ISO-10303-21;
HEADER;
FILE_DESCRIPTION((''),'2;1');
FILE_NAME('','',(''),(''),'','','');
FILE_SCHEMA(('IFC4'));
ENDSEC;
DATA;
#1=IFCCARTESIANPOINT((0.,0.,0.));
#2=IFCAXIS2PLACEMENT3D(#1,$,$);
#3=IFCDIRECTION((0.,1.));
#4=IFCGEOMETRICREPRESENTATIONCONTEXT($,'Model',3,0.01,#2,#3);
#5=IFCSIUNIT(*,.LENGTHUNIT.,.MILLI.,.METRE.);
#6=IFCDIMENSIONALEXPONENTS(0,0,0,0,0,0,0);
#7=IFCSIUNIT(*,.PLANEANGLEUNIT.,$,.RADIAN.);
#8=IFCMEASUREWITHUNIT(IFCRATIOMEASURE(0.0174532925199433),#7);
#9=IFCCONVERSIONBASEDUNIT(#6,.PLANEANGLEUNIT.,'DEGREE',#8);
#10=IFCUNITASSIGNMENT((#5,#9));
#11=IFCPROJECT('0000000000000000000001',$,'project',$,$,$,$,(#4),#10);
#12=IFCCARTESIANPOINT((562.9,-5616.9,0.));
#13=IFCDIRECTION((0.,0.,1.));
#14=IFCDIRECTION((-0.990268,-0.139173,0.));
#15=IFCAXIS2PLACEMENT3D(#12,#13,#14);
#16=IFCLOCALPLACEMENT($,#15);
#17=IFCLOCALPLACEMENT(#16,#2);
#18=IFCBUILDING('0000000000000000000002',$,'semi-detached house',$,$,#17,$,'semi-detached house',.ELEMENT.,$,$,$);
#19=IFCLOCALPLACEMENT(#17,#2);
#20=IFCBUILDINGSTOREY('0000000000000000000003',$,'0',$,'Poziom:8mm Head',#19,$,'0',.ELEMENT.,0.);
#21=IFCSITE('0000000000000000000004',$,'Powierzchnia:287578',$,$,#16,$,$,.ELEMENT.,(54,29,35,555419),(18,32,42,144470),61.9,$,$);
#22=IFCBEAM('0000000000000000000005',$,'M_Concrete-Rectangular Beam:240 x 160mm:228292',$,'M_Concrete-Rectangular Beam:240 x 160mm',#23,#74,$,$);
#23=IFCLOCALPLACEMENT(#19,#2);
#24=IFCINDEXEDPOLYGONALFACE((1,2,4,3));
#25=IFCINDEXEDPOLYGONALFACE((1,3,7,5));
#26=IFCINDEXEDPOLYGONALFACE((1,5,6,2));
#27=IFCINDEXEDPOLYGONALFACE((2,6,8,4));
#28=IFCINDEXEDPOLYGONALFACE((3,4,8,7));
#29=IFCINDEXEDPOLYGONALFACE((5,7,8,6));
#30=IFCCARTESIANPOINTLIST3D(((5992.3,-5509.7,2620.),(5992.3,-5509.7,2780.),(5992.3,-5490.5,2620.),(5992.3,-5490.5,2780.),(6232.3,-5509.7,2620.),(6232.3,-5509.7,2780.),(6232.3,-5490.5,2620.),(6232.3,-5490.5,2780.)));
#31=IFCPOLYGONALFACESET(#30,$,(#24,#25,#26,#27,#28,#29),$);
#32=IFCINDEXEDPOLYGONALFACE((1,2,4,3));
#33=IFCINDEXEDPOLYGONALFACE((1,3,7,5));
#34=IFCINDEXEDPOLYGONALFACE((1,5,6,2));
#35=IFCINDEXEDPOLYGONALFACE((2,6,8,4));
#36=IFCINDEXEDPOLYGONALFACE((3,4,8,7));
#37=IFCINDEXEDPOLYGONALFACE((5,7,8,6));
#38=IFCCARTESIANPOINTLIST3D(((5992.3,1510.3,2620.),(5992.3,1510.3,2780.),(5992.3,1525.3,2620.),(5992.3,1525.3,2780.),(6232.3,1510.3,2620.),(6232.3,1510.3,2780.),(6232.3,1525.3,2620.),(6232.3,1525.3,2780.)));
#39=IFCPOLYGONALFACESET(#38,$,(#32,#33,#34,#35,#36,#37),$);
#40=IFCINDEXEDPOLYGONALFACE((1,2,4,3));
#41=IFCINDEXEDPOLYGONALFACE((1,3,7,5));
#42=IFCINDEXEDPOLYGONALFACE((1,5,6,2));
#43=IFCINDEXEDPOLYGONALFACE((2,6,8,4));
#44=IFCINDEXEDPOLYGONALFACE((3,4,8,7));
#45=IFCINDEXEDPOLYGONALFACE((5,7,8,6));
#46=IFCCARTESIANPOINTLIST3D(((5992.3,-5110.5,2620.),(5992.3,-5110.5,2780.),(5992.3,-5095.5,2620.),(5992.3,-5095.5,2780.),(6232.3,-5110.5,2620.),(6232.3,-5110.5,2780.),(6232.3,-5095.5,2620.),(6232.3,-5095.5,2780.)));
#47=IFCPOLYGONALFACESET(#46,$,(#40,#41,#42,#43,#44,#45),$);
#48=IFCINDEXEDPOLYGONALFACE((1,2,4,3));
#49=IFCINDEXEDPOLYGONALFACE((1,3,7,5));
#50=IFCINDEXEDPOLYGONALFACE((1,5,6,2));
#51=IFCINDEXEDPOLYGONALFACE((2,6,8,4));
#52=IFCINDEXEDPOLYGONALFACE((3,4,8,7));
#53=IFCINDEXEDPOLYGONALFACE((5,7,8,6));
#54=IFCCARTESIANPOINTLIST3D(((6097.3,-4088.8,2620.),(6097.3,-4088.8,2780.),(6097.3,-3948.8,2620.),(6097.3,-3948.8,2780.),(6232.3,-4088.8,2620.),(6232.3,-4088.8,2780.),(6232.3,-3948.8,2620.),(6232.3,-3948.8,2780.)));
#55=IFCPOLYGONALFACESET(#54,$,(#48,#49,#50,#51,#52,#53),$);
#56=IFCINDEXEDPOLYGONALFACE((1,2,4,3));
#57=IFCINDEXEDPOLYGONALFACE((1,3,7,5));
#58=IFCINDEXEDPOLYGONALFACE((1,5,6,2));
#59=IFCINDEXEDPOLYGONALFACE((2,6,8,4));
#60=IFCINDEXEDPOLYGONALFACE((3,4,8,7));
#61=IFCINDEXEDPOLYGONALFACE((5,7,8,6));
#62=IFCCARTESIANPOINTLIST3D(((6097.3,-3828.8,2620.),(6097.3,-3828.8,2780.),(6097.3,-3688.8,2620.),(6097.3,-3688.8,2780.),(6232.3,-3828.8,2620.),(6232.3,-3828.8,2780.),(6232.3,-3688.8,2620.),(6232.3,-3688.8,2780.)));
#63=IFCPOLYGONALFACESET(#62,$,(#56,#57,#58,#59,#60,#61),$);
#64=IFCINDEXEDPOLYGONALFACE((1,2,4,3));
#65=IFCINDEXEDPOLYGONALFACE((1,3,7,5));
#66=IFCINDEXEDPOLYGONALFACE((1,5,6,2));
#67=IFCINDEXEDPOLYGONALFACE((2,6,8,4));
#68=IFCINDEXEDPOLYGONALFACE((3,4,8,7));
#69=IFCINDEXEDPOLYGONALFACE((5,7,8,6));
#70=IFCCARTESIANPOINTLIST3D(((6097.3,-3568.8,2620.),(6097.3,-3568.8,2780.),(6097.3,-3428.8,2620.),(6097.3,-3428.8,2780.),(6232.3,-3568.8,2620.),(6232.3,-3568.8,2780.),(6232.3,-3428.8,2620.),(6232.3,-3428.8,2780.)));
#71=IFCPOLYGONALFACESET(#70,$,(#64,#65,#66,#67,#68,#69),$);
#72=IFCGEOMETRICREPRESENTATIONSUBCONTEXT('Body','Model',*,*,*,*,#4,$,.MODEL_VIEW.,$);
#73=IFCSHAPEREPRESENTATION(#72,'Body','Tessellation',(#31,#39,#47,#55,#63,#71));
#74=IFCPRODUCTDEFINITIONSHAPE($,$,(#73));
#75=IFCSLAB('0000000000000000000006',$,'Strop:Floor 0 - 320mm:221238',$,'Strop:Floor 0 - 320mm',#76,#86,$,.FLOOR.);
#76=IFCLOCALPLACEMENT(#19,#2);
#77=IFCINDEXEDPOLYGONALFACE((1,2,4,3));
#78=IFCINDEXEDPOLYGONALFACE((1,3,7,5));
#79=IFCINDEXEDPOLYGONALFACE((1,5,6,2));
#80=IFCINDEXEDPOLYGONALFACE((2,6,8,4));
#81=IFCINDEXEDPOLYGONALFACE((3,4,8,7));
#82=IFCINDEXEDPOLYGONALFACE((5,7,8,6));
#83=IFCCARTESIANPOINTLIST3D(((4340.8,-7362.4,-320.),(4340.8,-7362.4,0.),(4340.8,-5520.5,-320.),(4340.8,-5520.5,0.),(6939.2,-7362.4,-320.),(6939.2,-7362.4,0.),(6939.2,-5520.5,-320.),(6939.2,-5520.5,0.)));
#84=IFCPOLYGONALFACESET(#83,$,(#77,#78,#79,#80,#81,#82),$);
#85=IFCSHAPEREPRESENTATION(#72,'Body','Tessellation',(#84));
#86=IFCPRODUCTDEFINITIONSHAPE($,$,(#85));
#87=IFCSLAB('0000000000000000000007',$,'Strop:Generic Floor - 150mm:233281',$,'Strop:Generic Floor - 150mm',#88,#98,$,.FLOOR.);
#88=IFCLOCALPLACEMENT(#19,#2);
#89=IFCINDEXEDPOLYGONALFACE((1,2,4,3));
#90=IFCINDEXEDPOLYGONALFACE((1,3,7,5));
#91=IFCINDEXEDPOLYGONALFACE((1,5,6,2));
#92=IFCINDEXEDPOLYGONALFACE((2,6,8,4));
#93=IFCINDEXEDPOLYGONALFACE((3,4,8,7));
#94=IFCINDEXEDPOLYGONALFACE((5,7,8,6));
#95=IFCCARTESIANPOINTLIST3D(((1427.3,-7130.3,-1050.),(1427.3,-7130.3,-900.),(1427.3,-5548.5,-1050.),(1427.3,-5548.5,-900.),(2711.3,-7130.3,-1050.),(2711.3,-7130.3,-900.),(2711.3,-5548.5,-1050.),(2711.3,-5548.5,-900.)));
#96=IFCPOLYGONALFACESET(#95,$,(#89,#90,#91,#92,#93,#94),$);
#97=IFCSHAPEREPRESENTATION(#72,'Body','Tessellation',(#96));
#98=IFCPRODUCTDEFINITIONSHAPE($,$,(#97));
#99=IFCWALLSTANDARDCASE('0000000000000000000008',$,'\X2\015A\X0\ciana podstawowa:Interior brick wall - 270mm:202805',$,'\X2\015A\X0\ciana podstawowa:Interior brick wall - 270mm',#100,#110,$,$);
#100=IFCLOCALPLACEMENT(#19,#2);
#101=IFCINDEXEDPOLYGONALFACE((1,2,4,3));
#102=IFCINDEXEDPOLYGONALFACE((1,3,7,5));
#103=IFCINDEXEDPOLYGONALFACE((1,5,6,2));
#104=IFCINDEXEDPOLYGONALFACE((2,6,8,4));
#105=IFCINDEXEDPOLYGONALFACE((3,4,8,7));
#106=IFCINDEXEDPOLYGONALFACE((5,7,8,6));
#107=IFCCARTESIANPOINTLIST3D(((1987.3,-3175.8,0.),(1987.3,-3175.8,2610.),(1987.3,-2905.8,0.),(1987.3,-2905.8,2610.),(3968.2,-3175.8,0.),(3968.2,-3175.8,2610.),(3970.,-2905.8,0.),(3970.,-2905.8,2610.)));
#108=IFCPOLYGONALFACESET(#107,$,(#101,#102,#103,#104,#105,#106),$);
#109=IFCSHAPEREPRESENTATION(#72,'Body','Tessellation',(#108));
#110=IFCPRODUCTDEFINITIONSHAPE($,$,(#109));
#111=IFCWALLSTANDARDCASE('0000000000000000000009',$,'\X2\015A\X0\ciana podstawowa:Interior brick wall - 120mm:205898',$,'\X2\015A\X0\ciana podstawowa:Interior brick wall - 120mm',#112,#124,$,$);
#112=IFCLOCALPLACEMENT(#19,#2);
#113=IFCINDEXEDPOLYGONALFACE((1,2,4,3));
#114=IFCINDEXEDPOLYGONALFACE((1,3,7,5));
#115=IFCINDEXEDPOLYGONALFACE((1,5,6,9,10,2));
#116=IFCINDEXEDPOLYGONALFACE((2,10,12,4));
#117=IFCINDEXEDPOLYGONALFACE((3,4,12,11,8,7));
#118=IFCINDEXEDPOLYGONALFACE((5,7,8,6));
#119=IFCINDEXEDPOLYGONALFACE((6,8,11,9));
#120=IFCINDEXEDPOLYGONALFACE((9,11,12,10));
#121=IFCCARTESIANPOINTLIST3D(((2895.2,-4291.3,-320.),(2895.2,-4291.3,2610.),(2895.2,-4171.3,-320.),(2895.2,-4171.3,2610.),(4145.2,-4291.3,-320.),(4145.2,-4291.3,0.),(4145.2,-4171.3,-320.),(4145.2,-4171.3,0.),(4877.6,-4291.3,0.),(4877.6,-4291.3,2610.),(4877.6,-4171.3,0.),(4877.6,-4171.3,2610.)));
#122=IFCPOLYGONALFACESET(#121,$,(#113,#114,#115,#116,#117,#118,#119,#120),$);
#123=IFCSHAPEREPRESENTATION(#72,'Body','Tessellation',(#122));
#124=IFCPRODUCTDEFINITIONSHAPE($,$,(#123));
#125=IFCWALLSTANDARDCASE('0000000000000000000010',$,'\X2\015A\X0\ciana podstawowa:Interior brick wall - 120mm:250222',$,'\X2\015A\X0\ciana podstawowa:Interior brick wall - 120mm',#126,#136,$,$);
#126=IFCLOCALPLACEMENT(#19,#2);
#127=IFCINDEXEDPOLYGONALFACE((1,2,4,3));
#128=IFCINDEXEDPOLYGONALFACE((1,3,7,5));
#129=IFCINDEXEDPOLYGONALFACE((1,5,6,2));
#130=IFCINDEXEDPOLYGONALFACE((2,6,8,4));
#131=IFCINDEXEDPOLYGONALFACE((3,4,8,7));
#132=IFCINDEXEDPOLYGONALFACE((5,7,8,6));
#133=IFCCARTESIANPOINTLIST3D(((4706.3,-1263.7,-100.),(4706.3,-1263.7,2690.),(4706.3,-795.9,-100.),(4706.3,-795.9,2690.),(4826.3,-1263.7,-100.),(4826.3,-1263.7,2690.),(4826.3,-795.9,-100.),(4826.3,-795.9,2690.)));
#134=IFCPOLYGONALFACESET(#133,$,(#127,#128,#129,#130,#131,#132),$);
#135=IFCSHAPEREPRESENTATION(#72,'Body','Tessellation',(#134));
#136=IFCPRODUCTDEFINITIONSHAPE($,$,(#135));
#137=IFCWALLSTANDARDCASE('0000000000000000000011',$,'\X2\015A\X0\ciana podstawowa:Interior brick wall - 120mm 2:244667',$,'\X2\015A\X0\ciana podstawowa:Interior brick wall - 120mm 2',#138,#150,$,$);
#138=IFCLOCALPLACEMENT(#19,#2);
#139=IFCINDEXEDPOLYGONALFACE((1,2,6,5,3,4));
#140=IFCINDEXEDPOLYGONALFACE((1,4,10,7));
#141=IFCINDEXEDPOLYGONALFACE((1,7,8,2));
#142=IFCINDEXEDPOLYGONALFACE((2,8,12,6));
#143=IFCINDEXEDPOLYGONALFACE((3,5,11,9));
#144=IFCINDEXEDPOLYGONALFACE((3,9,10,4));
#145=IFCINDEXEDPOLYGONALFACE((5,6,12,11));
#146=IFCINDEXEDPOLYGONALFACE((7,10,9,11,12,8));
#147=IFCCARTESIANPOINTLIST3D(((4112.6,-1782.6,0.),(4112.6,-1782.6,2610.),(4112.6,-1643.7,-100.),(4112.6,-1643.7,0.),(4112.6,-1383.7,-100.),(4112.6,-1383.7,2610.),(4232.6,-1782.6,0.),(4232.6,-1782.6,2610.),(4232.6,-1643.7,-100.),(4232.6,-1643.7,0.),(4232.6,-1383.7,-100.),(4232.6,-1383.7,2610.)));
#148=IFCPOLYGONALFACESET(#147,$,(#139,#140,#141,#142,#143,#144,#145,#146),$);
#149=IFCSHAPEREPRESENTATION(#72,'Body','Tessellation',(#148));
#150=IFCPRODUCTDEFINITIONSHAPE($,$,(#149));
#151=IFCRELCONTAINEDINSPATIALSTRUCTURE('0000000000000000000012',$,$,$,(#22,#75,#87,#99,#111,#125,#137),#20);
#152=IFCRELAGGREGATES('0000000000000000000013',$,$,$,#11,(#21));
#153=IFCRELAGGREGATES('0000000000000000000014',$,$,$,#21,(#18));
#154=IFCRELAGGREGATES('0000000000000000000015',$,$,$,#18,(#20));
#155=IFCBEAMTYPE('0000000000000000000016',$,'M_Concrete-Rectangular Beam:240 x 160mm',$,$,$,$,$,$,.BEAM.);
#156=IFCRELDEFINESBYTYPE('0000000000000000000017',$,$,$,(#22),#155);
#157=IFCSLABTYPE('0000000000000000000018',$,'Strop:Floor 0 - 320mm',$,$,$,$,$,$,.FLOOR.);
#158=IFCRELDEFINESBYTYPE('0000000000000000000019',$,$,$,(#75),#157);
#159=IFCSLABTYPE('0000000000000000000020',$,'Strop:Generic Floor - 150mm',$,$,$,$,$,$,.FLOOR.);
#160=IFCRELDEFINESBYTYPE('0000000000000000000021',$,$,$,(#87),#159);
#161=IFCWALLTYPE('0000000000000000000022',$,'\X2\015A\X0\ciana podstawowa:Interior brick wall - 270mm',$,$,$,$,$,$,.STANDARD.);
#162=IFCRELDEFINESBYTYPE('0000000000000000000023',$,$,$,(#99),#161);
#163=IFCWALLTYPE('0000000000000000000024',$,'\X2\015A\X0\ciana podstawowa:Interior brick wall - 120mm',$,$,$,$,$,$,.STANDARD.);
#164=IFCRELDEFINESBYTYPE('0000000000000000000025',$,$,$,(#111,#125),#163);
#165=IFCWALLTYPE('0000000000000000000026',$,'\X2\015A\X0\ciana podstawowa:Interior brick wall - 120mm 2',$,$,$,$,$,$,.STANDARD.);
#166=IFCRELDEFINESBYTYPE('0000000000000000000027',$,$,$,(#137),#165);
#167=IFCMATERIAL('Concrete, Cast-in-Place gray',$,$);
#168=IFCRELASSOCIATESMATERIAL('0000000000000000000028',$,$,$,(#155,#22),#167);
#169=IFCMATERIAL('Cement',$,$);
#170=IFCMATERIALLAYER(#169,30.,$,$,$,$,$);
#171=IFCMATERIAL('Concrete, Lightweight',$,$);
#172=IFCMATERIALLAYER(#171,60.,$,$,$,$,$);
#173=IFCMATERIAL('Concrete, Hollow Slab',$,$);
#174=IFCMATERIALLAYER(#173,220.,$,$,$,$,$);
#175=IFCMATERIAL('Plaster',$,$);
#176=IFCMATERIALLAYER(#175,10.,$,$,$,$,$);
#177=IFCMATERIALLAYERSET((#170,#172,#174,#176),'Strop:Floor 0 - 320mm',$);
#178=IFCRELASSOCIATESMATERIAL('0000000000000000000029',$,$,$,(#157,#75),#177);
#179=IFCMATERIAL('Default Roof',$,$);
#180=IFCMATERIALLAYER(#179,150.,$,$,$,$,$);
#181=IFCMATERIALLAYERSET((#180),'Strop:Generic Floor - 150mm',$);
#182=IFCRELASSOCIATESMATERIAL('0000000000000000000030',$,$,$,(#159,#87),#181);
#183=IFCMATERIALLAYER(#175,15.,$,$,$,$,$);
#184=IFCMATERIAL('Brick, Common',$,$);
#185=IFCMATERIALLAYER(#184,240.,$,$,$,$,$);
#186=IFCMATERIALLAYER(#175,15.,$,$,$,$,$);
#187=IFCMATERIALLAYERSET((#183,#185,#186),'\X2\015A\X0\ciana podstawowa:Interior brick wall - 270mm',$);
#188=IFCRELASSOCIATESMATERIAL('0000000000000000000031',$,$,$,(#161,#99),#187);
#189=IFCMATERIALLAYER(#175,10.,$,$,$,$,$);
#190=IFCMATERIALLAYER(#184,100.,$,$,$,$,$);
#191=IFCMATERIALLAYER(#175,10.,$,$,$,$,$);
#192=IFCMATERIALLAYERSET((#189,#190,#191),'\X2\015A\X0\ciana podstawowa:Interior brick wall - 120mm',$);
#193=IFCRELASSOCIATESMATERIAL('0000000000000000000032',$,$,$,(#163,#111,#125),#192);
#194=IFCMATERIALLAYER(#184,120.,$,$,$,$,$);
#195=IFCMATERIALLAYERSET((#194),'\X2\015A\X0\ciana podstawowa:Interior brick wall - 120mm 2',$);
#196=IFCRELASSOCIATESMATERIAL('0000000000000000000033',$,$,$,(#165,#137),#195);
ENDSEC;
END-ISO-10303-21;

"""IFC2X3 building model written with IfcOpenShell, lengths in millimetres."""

from ifc_helpers import new_model, entity, si_unit, converted_unit, direction, frame, frame_2d, origin, origin_2d_with_axis, place, context, subcontext, project, spatial, polyline, rectangle, outline, extrude, clip, bounded_halfspace, source, transform, mapped, material, layer, layer_set, layer_usage, type_object, type_shapes, element, save


model = new_model("IFC2X3")

# Units and contexts
model_context = context("Model", 3, precision=0.01, world=origin(), true_north=direction((0.0, 1.0)))
body_context = subcontext(model_context, "Body", "Model", "MODEL_VIEW")
ifc_project = project(units=[si_unit("LENGTHUNIT", "METRE", prefix="MILLI"), converted_unit("PLANEANGLEUNIT", "DEGREE", entity("IfcRatioMeasure", 0.0174532925199433), si_unit("PLANEANGLEUNIT", "RADIAN"), dimensions=[0, 0, 0, 0, 0, 0, 0])], contexts=[model_context])

# Site, building, storey
site_placement = place(None, frame((562.9, -5616.9, 0.0), z_axis=(0.0, 0.0, 1.0), x_axis=(-0.990268, -0.139173, 0.0)))
site = spatial("IfcSite", under=ifc_project, at=site_placement, Name="Powierzchnia:287578", CompositionType="ELEMENT", RefLatitude=(54, 29, 35, 555419), RefLongitude=(18, 32, 42, 144470), RefElevation=61.9)
building_placement = place(site_placement, origin())
building = spatial("IfcBuilding", under=site, at=building_placement, Name="semi-detached house", LongName="semi-detached house", CompositionType="ELEMENT")
storey_placement = place(building_placement, origin())
storey = spatial("IfcBuildingStorey", under=building, at=storey_placement, Name="0", ObjectType="Poziom:8mm Head", LongName="0", CompositionType="ELEMENT", Elevation=0.0)

# Beam
ifc_material_1 = material(Name="Concrete, Cast-in-Place gray")
beam_type_1 = type_object("IfcBeamType", Name="M_Concrete-Rectangular Beam:240 x 160mm", PredefinedType="BEAM", material=ifc_material_1)
shared_shape_1 = source(origin(), body_context, "Body", "SweptSolid", [
    extrude(rectangle(XDim=160.0, YDim=240.0, at=frame_2d((0.0, 0.0), x_axis=(0.0, 1.0))), frame((6112.3, -5490.5, 2700.0), z_axis=(0.0, -1.0, 0.0), x_axis=(-1.0, 0.0, 0.0)), (0.0, 0.0, 1.0), 19.2),
    extrude(rectangle(XDim=160.0, YDim=240.0, at=frame_2d((0.0, 0.0), x_axis=(0.0, 1.0))), frame((6112.3, 1525.3, 2700.0), z_axis=(0.0, -1.0, 0.0), x_axis=(-1.0, 0.0, 0.0)), (0.0, 0.0, 1.0), 15.0),
    extrude(rectangle(XDim=160.0, YDim=240.0, at=frame_2d((0.0, 0.0), x_axis=(0.0, 1.0))), frame((6112.3, -5095.5, 2700.0), z_axis=(0.0, -1.0, 0.0), x_axis=(-1.0, 0.0, 0.0)), (0.0, 0.0, 1.0), 15.0),
    extrude(rectangle(XDim=160.0, YDim=135.0, at=frame_2d((0.0, 0.0), x_axis=(1.0, 0.0))), frame((6164.8, -3948.8, 2700.0), z_axis=(0.0, -1.0, 0.0), x_axis=(0.0, 0.0, -1.0)), (0.0, 0.0, 1.0), 140.0),
    extrude(rectangle(XDim=160.0, YDim=135.0, at=frame_2d((0.0, 0.0), x_axis=(1.0, 0.0))), frame((6164.8, -3688.8, 2700.0), z_axis=(0.0, -1.0, 0.0), x_axis=(0.0, 0.0, -1.0)), (0.0, 0.0, 1.0), 140.0),
    extrude(rectangle(XDim=160.0, YDim=135.0, at=frame_2d((0.0, 0.0), x_axis=(1.0, 0.0))), frame((6164.8, -3428.8, 2700.0), z_axis=(0.0, -1.0, 0.0), x_axis=(0.0, 0.0, -1.0)), (0.0, 0.0, 1.0), 140.0),
])
type_shapes(beam_type_1, [shared_shape_1])
beam_1_placement = place(storey_placement, origin())
element("IfcBeam", 1, at=beam_1_placement, inside=storey, type_object=beam_type_1, material=ifc_material_1, Name="M_Concrete-Rectangular Beam:240 x 160mm:228292", ObjectType="M_Concrete-Rectangular Beam:240 x 160mm", context=body_context, shape_type="MappedRepresentation", body=[
    mapped(shared_shape_1, transform((0.0, 0.0, 0.0), scale=1.0)),
])

# Slabs
ifc_material_2 = material(Name="Cement")
ifc_layer_1 = layer(ifc_material_2, 30.0)
ifc_material_3 = material(Name="Concrete, Lightweight")
ifc_layer_2 = layer(ifc_material_3, 60.0)
ifc_material_4 = material(Name="Concrete, Hollow Slab")
ifc_layer_3 = layer(ifc_material_4, 220.0)
ifc_material_5 = material(Name="Plaster")
ifc_layer_4 = layer(ifc_material_5, 10.0)
ifc_layer_set_1 = layer_set([ifc_layer_1, ifc_layer_2, ifc_layer_3, ifc_layer_4], Name="Strop:Floor 0 - 320mm")
ifc_layer_usage_1 = layer_usage(ifc_layer_set_1, "AXIS3", "POSITIVE", 0.0)
slab_type_1 = type_object("IfcSlabType", Name="Strop:Floor 0 - 320mm", PredefinedType="FLOOR", material=ifc_layer_set_1)
slab_1_placement = place(storey_placement, origin())
element("IfcSlab", 2, at=slab_1_placement, inside=storey, type_object=slab_type_1, material=ifc_layer_usage_1, Name="Strop:Floor 0 - 320mm:221238", ObjectType="Strop:Floor 0 - 320mm", PredefinedType="FLOOR", context=body_context, shape_type="SweptSolid", body=[
    extrude(rectangle(XDim=1841.8, YDim=2598.3, at=frame_2d((0.0, 0.0), x_axis=(1.0, 0.0))), frame((5640.0, -6441.4, 0.0), z_axis=(0.0, 0.0, -1.0), x_axis=(0.0, 1.0, 0.0)), (0.0, 0.0, 1.0), 320.0),
])
ifc_material_6 = material(Name="Default Roof")
ifc_layer_5 = layer(ifc_material_6, 150.0)
ifc_layer_set_2 = layer_set([ifc_layer_5], Name="Strop:Generic Floor - 150mm")
ifc_layer_usage_2 = layer_usage(ifc_layer_set_2, "AXIS3", "POSITIVE", 0.0)
slab_type_2 = type_object("IfcSlabType", Name="Strop:Generic Floor - 150mm", PredefinedType="FLOOR", material=ifc_layer_set_2)
slab_2_placement = place(storey_placement, origin())
element("IfcSlab", 3, at=slab_2_placement, inside=storey, type_object=slab_type_2, material=ifc_layer_usage_2, Name="Strop:Generic Floor - 150mm:233281", ObjectType="Strop:Generic Floor - 150mm", PredefinedType="FLOOR", context=body_context, shape_type="SweptSolid", body=[
    extrude(rectangle(XDim=1581.8, YDim=1284.0, at=origin_2d_with_axis()), frame((2069.3, -6339.4, -900.0), z_axis=(0.0, 0.0, -1.0), x_axis=(0.0, 1.0, 0.0)), (0.0, 0.0, 1.0), 150.0),
])

# Shared definitions
ifc_material_7 = material(Name="Brick, Common")

# Wall
ifc_layer_6 = layer(ifc_material_5, 15.0)
ifc_layer_7 = layer(ifc_material_7, 240.0)
ifc_layer_8 = layer(ifc_material_5, 15.0)
ifc_layer_set_3 = layer_set([ifc_layer_6, ifc_layer_7, ifc_layer_8], Name="Ściana podstawowa:Interior brick wall - 270mm")
ifc_layer_usage_3 = layer_usage(ifc_layer_set_3, "AXIS2", "NEGATIVE", 135.0)
wall_type_1 = type_object("IfcWallType", Name="Ściana podstawowa:Interior brick wall - 270mm", PredefinedType="STANDARD", material=ifc_layer_set_3)
wall_1_placement = place(storey_placement, frame((1987.3, -3040.8, 0.0)))
element("IfcWallStandardCase", 4, at=wall_1_placement, inside=storey, type_object=wall_type_1, material=ifc_layer_usage_3, Name="Ściana podstawowa:Interior brick wall - 270mm:202805", ObjectType="Ściana podstawowa:Interior brick wall - 270mm", context=body_context, shape_type="Clipping", body=[
    clip(extrude(outline(polyline([(0.0, -135.0), (1980.9, -135.0), (1982.7, 135.0), (1782.7, 135.0), (0.0, 135.0), (0.0, -135.0)])), origin(), (0.0, 0.0, 1.0), 2610.0), bounded_halfspace(frame((1980.9, -135.0, 0.0), z_axis=(0.0, 0.0, 1.0), x_axis=(0.0, -1.0, 0.0)), True, frame((1980.9, -135.0, 0.0), z_axis=(0.0, 0.0, 1.0), x_axis=(0.0, -1.0, 0.0)), polyline([(0.0, 0.0), (-270.0, 1.8), (-270.0, -1980.9), (0.0, -1980.9), (0.0, 0.0)]))),
])

# Walls
ifc_layer_9 = layer(ifc_material_5, 10.0)
ifc_layer_10 = layer(ifc_material_7, 100.0)
ifc_layer_11 = layer(ifc_material_5, 10.0)
ifc_layer_set_4 = layer_set([ifc_layer_9, ifc_layer_10, ifc_layer_11], Name="Ściana podstawowa:Interior brick wall - 120mm")
ifc_layer_usage_4 = layer_usage(ifc_layer_set_4, "AXIS2", "NEGATIVE", 60.0)
wall_type_2 = type_object("IfcWallType", Name="Ściana podstawowa:Interior brick wall - 120mm", PredefinedType="STANDARD", material=ifc_layer_set_4)
wall_2_placement = place(storey_placement, frame((2895.2, -4231.3, -320.0)))
element("IfcWallStandardCase", 5, at=wall_2_placement, inside=storey, type_object=wall_type_2, material=ifc_layer_usage_4, Name="Ściana podstawowa:Interior brick wall - 120mm:205898", ObjectType="Ściana podstawowa:Interior brick wall - 120mm", context=body_context, shape_type="Clipping", body=[
    clip(clip(extrude(rectangle(XDim=1982.4, YDim=120.0, at=frame_2d((991.2, 0.0), x_axis=(-1.0, 0.0))), origin(), (0.0, 0.0, 1.0), 2930.0), bounded_halfspace(frame((1250.0, -60.0, 320.0), z_axis=(0.0, 0.0, 1.0), x_axis=(0.0, -1.0, 0.0)), True, frame((1250.0, -60.0, 320.0), z_axis=(0.0, 0.0, 1.0), x_axis=(0.0, -1.0, 0.0)), polyline([(0.0, 0.0), (0.0, 732.4), (-120.0, 732.4), (-120.0, 334.6), (-120.0, 0.0), (0.0, 0.0)]))), bounded_halfspace(frame((1250.0, 60.0, 320.0), z_axis=(-1.0, 0.0, 0.0), x_axis=(0.0, 0.0, 1.0)), True, frame((1250.0, 60.0, 320.0), z_axis=(-1.0, 0.0, 0.0), x_axis=(0.0, 0.0, 1.0)), polyline([(0.0, 0.0), (-320.0, 0.0), (-320.0, -120.0), (0.0, -120.0), (0.0, 0.0)]))),
])
ifc_layer_usage_5 = layer_usage(ifc_layer_set_4, "AXIS2", "POSITIVE", -60.0)
wall_3_placement = place(storey_placement, frame((4766.3, -795.9, -100.0), z_axis=(0.0, 0.0, 1.0), x_axis=(0.0, -1.0, 0.0)))
element("IfcWallStandardCase", 6, at=wall_3_placement, inside=storey, type_object=wall_type_2, material=ifc_layer_usage_5, Name="Ściana podstawowa:Interior brick wall - 120mm:250222", ObjectType="Ściana podstawowa:Interior brick wall - 120mm", context=body_context, shape_type="SweptSolid", body=[
    extrude(rectangle(XDim=467.9, YDim=120.0, at=frame_2d((233.9, 0.0), x_axis=(-1.0, 0.0))), origin(), (0.0, 0.0, 1.0), 2790.0),
])
ifc_layer_12 = layer(ifc_material_7, 120.0)
ifc_layer_set_5 = layer_set([ifc_layer_12], Name="Ściana podstawowa:Interior brick wall - 120mm 2")
wall_type_3 = type_object("IfcWallType", Name="Ściana podstawowa:Interior brick wall - 120mm 2", PredefinedType="STANDARD", material=ifc_layer_set_5)
ifc_layer_usage_6 = layer_usage(ifc_layer_set_5, "AXIS2", "POSITIVE", -60.0)
wall_4_placement = place(storey_placement, frame((4172.6, -1383.7, -100.0), z_axis=(0.0, 0.0, 1.0), x_axis=(0.0, -1.0, 0.0)))
element("IfcWallStandardCase", 7, at=wall_4_placement, inside=storey, type_object=wall_type_3, material=ifc_layer_usage_6, Name="Ściana podstawowa:Interior brick wall - 120mm 2:244667", ObjectType="Ściana podstawowa:Interior brick wall - 120mm 2", context=body_context, shape_type="Clipping", body=[
    clip(clip(clip(extrude(rectangle(XDim=398.9, YDim=120.0, at=frame_2d((199.5, 0.0), x_axis=(-1.0, 0.0))), origin(), (0.0, 0.0, 1.0), 2710.0), bounded_halfspace(frame((0.0, -60.0, 2710.0), z_axis=(0.0, 0.0, -1.0), x_axis=(0.0, 1.0, 0.0)), True, frame((0.0, -60.0, 2710.0)), polyline([(0.0, 0.0), (138.9, 0.0), (140.0, 0.0), (260.0, 0.0), (398.9, 0.0), (398.9, 120.0), (260.0, 120.0), (140.0, 120.0), (138.9, 120.0), (0.0, 120.0), (0.0, 0.0)]))), bounded_halfspace(frame((260.0, -60.0, 100.0)), True, frame((260.0, -60.0, 100.0)), polyline([(0.0, 0.0), (138.9, 0.0), (138.9, 120.0), (0.0, 120.0), (0.0, 0.0)]))), bounded_halfspace(frame((260.0, 60.0, 100.0), z_axis=(-1.0, 0.0, 0.0), x_axis=(0.0, 0.0, 1.0)), True, frame((260.0, 60.0, 100.0), z_axis=(-1.0, 0.0, 0.0), x_axis=(0.0, 0.0, 1.0)), polyline([(0.0, 0.0), (-100.0, 0.0), (-100.0, -120.0), (0.0, -120.0), (0.0, 0.0)]))),
])

save(model, "model.ifc")
